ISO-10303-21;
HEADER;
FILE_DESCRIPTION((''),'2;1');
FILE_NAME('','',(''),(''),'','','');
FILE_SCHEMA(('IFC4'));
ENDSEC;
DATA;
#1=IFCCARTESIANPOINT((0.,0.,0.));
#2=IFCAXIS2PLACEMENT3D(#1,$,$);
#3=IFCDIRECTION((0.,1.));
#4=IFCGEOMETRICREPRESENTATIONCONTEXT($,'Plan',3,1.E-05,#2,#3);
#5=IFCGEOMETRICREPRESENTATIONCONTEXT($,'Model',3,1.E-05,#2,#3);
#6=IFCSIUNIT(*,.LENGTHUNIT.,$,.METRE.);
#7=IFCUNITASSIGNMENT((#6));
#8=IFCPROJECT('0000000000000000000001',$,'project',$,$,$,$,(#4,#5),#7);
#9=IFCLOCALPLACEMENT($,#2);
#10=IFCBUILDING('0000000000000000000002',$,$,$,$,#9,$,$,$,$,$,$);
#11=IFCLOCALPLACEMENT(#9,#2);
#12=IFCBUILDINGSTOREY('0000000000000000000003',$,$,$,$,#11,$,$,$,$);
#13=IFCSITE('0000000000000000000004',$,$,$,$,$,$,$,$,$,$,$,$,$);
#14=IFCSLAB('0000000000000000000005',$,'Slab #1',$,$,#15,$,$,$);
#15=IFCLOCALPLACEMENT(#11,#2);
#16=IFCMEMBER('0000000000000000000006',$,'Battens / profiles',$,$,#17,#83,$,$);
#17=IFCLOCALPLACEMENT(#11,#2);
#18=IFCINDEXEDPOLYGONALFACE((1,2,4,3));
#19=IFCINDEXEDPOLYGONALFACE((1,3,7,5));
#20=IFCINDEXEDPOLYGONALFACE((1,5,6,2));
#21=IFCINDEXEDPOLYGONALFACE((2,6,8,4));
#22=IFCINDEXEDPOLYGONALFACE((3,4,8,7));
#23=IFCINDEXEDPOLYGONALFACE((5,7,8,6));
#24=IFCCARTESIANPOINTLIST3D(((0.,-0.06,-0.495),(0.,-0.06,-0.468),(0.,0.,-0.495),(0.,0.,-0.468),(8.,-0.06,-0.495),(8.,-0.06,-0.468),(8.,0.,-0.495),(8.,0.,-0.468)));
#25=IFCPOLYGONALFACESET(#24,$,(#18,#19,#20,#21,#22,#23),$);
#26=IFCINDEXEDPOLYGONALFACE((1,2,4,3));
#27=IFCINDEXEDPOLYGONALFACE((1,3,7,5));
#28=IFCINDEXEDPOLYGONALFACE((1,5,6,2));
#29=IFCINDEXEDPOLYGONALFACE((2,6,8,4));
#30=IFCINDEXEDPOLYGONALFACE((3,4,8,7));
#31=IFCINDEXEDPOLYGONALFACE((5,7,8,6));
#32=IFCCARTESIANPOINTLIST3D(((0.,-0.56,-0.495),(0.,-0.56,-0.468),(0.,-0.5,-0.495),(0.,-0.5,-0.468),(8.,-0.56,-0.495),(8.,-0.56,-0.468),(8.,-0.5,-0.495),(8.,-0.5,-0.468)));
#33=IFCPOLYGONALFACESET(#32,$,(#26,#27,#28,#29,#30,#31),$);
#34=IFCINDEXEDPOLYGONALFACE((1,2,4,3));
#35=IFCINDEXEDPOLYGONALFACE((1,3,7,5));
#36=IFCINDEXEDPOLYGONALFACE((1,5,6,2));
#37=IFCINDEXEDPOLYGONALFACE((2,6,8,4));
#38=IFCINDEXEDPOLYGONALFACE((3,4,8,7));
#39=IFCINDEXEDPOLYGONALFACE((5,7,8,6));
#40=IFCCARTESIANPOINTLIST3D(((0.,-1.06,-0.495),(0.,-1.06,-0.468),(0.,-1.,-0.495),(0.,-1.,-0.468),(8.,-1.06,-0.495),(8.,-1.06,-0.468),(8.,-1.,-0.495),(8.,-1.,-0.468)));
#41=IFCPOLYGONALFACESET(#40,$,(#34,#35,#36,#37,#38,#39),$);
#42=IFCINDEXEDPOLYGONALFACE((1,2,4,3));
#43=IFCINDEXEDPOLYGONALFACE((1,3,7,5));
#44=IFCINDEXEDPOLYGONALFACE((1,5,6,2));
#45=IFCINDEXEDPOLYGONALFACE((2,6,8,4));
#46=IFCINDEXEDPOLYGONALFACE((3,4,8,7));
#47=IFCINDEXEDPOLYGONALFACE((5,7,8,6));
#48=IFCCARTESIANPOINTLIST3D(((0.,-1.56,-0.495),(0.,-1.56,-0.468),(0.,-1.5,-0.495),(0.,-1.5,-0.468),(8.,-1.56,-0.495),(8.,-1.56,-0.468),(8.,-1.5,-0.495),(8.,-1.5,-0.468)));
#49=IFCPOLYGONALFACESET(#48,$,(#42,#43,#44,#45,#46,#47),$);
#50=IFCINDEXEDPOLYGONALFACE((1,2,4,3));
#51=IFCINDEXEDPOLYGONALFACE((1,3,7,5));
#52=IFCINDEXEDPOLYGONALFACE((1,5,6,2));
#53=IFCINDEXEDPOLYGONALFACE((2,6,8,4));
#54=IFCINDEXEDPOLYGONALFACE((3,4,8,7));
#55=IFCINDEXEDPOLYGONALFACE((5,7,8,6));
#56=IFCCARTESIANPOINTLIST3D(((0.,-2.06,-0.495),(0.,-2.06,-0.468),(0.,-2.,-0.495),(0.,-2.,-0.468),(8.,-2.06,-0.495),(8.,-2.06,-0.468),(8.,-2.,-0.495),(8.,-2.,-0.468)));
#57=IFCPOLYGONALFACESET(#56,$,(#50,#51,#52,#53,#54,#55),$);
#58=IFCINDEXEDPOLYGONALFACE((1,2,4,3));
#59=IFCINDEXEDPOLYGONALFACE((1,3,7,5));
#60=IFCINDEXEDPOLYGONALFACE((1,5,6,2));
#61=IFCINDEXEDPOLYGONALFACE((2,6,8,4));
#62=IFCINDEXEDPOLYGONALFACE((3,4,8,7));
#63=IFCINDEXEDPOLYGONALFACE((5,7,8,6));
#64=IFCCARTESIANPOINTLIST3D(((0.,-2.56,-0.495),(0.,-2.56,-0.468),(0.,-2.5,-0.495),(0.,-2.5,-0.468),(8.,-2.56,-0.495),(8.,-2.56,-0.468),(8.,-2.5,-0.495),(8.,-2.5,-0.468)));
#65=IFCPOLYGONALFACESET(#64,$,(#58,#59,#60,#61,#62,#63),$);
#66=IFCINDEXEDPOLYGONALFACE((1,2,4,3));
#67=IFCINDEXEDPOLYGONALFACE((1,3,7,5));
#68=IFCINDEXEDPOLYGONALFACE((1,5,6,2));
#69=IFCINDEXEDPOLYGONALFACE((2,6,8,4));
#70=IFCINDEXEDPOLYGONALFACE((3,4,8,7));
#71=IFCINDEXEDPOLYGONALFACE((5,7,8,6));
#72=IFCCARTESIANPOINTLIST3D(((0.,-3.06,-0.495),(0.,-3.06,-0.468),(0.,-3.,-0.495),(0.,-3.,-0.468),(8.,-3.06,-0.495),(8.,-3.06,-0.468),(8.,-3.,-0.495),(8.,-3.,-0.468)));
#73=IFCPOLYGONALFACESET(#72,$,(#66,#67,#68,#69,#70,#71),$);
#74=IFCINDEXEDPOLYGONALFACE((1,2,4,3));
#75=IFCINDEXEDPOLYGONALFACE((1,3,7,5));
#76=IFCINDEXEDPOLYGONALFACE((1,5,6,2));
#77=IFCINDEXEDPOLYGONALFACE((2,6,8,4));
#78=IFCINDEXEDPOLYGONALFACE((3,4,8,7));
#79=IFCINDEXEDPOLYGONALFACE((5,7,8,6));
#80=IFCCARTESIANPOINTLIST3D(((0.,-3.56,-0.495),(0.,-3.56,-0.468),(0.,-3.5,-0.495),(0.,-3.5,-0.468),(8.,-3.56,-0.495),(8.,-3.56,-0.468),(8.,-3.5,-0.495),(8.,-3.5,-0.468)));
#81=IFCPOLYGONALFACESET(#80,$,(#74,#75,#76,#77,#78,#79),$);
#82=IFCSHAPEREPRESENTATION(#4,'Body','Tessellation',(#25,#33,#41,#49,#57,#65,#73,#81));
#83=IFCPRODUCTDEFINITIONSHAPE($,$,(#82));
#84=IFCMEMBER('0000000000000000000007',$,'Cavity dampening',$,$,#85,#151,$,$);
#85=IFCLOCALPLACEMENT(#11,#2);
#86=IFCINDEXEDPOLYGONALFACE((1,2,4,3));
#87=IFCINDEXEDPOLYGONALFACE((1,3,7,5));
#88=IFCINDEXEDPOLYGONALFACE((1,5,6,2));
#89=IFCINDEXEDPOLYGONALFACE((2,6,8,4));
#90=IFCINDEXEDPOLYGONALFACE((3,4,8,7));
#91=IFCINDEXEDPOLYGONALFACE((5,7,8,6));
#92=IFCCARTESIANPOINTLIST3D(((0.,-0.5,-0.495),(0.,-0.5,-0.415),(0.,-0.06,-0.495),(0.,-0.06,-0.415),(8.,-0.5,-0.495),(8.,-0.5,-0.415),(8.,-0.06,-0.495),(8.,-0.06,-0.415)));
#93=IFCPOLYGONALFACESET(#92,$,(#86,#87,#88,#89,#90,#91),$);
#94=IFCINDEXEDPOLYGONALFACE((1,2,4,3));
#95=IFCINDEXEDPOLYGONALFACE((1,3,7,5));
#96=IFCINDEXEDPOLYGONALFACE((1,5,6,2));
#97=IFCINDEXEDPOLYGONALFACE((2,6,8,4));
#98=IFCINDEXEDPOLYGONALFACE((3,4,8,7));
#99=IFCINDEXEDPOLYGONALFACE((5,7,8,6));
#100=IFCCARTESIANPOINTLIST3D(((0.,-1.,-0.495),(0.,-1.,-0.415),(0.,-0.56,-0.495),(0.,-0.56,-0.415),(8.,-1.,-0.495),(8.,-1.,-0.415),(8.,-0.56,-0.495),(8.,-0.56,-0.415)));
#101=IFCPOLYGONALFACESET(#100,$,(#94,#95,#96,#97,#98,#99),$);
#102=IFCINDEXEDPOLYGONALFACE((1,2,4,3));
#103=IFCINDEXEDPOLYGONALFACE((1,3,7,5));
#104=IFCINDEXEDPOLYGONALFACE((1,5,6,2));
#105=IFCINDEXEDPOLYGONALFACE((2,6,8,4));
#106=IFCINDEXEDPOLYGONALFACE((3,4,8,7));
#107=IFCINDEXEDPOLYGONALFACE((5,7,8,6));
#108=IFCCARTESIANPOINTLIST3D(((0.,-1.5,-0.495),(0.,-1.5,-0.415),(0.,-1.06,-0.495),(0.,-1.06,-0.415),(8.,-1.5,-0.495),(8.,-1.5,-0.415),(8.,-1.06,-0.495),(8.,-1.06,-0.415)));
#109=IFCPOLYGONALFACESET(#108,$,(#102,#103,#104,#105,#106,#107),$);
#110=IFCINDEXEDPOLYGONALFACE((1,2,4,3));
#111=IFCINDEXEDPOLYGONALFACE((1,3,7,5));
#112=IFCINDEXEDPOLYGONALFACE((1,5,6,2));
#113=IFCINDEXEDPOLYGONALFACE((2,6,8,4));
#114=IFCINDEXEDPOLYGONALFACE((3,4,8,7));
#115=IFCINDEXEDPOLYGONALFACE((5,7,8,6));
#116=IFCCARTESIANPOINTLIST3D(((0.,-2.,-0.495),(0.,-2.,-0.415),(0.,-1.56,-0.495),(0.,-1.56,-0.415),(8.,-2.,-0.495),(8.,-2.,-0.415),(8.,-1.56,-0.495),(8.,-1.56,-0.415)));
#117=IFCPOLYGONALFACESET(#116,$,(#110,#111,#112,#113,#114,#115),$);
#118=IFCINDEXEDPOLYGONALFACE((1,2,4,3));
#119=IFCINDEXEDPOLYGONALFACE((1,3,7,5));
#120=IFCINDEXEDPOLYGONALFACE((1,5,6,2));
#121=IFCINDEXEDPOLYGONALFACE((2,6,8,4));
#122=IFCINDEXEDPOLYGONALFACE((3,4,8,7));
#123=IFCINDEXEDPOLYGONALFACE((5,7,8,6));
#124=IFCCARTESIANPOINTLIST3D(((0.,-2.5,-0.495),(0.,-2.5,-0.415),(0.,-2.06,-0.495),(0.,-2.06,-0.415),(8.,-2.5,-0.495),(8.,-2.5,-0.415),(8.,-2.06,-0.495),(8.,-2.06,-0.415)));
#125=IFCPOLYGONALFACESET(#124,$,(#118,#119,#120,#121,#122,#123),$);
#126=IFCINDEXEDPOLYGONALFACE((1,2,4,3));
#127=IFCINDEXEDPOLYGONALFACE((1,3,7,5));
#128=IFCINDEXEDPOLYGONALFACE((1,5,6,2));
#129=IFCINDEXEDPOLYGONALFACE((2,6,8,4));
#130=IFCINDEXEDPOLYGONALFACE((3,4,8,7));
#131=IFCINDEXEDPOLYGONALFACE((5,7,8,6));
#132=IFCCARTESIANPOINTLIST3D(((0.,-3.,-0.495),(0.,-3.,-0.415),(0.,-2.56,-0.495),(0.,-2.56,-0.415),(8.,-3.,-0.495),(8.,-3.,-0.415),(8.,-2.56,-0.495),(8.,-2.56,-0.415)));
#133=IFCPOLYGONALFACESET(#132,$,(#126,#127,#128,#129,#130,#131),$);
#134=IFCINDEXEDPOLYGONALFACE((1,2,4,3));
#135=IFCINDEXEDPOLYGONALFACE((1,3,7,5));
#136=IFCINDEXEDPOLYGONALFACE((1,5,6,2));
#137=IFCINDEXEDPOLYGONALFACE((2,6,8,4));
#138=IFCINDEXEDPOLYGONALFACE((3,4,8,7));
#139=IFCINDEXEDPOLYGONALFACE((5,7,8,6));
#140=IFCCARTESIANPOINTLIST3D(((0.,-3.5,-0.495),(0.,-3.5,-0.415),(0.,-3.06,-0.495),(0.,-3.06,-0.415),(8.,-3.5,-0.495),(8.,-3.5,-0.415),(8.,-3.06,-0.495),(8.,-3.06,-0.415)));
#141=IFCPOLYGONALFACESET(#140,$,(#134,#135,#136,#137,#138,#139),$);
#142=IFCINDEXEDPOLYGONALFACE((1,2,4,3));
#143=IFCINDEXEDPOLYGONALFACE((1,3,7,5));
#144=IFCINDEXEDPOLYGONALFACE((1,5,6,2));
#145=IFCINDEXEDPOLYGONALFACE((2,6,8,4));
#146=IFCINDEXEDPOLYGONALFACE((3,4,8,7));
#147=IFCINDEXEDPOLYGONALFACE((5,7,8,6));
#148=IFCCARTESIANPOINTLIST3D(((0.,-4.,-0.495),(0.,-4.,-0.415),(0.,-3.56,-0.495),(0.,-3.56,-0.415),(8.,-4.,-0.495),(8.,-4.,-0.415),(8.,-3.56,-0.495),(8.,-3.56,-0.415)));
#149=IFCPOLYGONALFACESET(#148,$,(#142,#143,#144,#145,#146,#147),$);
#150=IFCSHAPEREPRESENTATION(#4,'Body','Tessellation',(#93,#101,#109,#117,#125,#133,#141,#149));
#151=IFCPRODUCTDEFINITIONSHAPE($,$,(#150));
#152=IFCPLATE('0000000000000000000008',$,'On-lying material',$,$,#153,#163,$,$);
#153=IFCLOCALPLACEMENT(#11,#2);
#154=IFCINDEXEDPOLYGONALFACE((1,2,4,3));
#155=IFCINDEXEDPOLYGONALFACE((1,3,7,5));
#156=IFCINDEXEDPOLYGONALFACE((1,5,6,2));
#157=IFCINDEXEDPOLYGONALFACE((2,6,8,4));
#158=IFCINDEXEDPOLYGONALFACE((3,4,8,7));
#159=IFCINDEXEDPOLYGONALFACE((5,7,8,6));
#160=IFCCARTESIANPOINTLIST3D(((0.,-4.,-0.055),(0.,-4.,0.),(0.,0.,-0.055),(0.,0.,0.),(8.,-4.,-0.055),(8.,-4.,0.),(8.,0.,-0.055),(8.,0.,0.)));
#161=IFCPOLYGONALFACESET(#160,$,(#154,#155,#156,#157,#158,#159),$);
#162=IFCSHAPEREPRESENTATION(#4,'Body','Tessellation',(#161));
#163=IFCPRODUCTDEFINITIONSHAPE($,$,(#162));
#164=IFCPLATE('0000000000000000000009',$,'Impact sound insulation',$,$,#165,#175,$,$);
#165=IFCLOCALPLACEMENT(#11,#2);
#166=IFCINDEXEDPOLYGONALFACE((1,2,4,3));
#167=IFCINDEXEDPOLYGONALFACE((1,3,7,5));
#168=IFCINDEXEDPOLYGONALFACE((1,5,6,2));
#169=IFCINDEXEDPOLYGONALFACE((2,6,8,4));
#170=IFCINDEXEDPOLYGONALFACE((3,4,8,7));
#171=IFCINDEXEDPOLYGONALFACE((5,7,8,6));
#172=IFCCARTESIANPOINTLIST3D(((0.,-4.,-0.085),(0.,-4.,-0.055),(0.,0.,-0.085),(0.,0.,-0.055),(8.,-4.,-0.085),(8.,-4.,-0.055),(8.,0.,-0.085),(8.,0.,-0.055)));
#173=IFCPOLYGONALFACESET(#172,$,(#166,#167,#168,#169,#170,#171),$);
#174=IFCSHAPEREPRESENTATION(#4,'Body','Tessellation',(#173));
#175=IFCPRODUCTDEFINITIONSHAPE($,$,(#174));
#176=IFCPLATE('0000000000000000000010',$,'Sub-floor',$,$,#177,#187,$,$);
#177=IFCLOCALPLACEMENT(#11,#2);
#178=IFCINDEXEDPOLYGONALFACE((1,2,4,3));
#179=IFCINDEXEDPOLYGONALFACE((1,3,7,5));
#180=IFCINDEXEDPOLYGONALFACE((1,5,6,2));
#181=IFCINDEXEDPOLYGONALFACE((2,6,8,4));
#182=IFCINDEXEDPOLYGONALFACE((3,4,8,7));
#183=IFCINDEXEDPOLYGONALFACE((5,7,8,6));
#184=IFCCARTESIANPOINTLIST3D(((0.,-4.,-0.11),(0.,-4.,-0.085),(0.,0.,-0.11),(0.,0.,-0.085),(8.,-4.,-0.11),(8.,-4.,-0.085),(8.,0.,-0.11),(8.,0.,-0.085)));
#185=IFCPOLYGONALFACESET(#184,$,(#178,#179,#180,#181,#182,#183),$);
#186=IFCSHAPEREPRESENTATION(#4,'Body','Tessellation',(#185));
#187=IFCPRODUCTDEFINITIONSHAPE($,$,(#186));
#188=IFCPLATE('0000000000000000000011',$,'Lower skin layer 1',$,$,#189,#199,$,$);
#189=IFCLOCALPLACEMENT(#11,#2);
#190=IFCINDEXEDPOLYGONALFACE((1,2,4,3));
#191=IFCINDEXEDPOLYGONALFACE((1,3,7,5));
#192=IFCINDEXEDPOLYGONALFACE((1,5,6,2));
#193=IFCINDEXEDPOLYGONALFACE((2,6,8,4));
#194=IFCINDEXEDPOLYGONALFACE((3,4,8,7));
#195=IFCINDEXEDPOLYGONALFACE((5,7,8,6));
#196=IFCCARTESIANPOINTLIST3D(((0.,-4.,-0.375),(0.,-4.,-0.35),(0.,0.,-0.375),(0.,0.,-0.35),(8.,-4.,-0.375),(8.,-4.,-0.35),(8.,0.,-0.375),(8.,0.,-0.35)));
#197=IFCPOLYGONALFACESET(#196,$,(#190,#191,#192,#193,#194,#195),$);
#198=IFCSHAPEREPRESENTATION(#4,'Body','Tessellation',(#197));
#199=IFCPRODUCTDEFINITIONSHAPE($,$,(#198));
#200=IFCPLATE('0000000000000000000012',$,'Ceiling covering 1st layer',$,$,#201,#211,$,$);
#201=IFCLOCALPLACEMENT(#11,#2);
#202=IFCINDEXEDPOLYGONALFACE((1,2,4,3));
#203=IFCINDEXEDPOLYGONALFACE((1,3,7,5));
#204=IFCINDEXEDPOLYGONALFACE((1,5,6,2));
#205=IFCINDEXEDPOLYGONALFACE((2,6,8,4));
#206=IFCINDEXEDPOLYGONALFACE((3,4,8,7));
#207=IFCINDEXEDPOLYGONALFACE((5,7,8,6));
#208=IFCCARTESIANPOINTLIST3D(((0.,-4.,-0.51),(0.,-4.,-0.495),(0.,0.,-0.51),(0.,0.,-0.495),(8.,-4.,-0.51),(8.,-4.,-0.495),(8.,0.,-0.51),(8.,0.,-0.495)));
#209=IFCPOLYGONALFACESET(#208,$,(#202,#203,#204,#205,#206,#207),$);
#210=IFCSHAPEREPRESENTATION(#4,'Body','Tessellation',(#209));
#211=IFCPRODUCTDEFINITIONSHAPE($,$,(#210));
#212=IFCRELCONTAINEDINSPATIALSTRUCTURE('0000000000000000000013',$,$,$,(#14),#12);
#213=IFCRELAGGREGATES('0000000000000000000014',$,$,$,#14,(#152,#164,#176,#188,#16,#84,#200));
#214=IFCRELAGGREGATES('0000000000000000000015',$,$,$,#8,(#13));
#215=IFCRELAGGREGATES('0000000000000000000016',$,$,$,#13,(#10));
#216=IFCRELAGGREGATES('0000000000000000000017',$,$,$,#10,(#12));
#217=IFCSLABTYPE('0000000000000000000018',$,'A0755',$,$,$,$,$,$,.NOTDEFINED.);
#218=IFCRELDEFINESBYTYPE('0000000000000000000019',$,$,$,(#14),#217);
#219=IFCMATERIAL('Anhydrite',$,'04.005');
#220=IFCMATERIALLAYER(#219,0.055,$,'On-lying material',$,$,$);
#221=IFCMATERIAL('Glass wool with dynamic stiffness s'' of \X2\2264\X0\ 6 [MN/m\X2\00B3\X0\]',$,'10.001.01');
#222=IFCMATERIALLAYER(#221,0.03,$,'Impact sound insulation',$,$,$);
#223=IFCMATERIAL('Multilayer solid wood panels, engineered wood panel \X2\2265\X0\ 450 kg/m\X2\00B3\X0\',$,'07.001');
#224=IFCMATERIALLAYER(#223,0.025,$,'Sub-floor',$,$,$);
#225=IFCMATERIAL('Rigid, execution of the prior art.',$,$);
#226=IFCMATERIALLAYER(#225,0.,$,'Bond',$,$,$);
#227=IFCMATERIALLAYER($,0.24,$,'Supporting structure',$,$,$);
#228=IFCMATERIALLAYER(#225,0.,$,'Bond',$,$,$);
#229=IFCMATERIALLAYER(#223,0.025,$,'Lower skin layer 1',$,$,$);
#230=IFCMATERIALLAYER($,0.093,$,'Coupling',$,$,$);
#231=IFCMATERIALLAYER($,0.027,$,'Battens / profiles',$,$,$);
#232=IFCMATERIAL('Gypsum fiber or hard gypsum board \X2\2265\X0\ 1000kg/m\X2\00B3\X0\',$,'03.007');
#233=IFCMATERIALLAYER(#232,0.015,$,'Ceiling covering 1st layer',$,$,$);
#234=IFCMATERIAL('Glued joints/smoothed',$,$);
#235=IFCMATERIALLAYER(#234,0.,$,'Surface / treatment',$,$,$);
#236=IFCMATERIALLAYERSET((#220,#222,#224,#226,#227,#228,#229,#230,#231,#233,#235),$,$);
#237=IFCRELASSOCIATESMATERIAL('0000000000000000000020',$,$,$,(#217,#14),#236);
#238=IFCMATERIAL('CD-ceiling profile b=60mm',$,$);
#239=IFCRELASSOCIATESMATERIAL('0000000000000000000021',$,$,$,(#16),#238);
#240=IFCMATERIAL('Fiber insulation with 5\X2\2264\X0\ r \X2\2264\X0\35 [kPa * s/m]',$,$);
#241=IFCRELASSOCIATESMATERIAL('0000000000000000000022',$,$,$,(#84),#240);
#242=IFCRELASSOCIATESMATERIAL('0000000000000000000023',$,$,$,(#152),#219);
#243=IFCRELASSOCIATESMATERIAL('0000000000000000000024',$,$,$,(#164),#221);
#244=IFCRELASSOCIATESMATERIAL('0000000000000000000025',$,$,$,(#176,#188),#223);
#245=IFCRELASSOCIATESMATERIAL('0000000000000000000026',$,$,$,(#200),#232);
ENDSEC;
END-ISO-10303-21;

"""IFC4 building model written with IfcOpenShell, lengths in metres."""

from ifc_helpers import new_model, si_unit, direction, frame, frame_2d, origin, origin_with_axes, place, context, project, spatial, rectangle, extrude, material, layer, layer_set, type_object, element, aggregate, save


model = new_model("IFC4")

# Units and contexts
plan_context = context("Plan", 3, precision=1e-05, world=origin(), true_north=direction((0.0, 1.0)))
model_context = context("Model", 3, precision=1e-05, world=origin(), true_north=direction((0.0, 1.0)))
ifc_project = project(units=[si_unit("LENGTHUNIT", "METRE")], contexts=[plan_context, model_context])

# Site, building, storey
site = spatial("IfcSite", under=ifc_project)
building_placement = place(None, origin())
building = spatial("IfcBuilding", under=site, at=building_placement)
storey_placement = place(building_placement, origin())
storey = spatial("IfcBuildingStorey", under=building, at=storey_placement)

# Slab, members, plates
ifc_material_1 = material(Name="Anhydrite", Category="04.005")
ifc_layer_1 = layer(ifc_material_1, 0.055, Name="On-lying material")
ifc_material_2 = material(Name="Glass wool with dynamic stiffness s' of ≤ 6 [MN/m³]", Category="10.001.01")
ifc_layer_2 = layer(ifc_material_2, 0.03, Name="Impact sound insulation")
ifc_material_3 = material(Name="Multilayer solid wood panels, engineered wood panel ≥ 450 kg/m³", Category="07.001")
ifc_layer_3 = layer(ifc_material_3, 0.025, Name="Sub-floor")
ifc_material_4 = material(Name="Rigid, execution of the prior art.")
ifc_layer_4 = layer(ifc_material_4, 0.0, Name="Bond")
ifc_layer_5 = layer(None, 0.24, Name="Supporting structure")
ifc_layer_6 = layer(ifc_material_4, 0.0, Name="Bond")
ifc_layer_7 = layer(ifc_material_3, 0.025, Name="Lower skin layer 1")
ifc_layer_8 = layer(None, 0.093, Name="Coupling")
ifc_layer_9 = layer(None, 0.027, Name="Battens / profiles")
ifc_material_5 = material(Name="Gypsum fiber or hard gypsum board ≥ 1000kg/m³", Category="03.007")
ifc_layer_10 = layer(ifc_material_5, 0.015, Name="Ceiling covering 1st layer")
ifc_material_6 = material(Name="Glued joints/smoothed")
ifc_layer_11 = layer(ifc_material_6, 0.0, Name="Surface / treatment")
ifc_layer_set = layer_set([ifc_layer_1, ifc_layer_2, ifc_layer_3, ifc_layer_4, ifc_layer_5, ifc_layer_6, ifc_layer_7, ifc_layer_8, ifc_layer_9, ifc_layer_10, ifc_layer_11])
slab_type = type_object("IfcSlabType", Name="A0755", PredefinedType="NOTDEFINED", material=ifc_layer_set)
slab_placement = place(None, frame((0.0, 0.0, 0.0), z_axis=(0.0, 0.0, -1.0), x_axis=(1.0, 0.0, 0.0)))
slab = element("IfcSlab", 1, at=slab_placement, inside=storey, type_object=slab_type, material=ifc_layer_set, Name="Slab #1")
ifc_material_7 = material(Name="CD-ceiling profile b=60mm")
member_1_placement = place(slab_placement, origin())
member_1 = element("IfcMember", 2, at=member_1_placement, material=ifc_material_7, Name="Battens / profiles", context=plan_context, shape_type="SweptSolid", body=[
    extrude(rectangle(XDim=0.06, YDim=0.027, at=frame_2d((0.03, 0.0135), x_axis=(1.0, 0.0))), frame((0.0, 0.0, 0.468), z_axis=(1.0, 0.0, 0.0), x_axis=(0.0, 1.0, 0.0)), (0.0, 0.0, 1.0), 8.0),
    extrude(rectangle(XDim=0.06, YDim=0.027, at=frame_2d((0.03, 0.0135), x_axis=(1.0, 0.0))), frame((0.0, 0.5, 0.468), z_axis=(1.0, 0.0, 0.0), x_axis=(0.0, 1.0, 0.0)), (0.0, 0.0, 1.0), 8.0),
    extrude(rectangle(XDim=0.06, YDim=0.027, at=frame_2d((0.03, 0.0135), x_axis=(1.0, 0.0))), frame((0.0, 1.0, 0.468), z_axis=(1.0, 0.0, 0.0), x_axis=(0.0, 1.0, 0.0)), (0.0, 0.0, 1.0), 8.0),
    extrude(rectangle(XDim=0.06, YDim=0.027, at=frame_2d((0.03, 0.0135), x_axis=(1.0, 0.0))), frame((0.0, 1.5, 0.468), z_axis=(1.0, 0.0, 0.0), x_axis=(0.0, 1.0, 0.0)), (0.0, 0.0, 1.0), 8.0),
    extrude(rectangle(XDim=0.06, YDim=0.027, at=frame_2d((0.03, 0.0135), x_axis=(1.0, 0.0))), frame((0.0, 2.0, 0.468), z_axis=(1.0, 0.0, 0.0), x_axis=(0.0, 1.0, 0.0)), (0.0, 0.0, 1.0), 8.0),
    extrude(rectangle(XDim=0.06, YDim=0.027, at=frame_2d((0.03, 0.0135), x_axis=(1.0, 0.0))), frame((0.0, 2.5, 0.468), z_axis=(1.0, 0.0, 0.0), x_axis=(0.0, 1.0, 0.0)), (0.0, 0.0, 1.0), 8.0),
    extrude(rectangle(XDim=0.06, YDim=0.027, at=frame_2d((0.03, 0.0135), x_axis=(1.0, 0.0))), frame((0.0, 3.0, 0.468), z_axis=(1.0, 0.0, 0.0), x_axis=(0.0, 1.0, 0.0)), (0.0, 0.0, 1.0), 8.0),
    extrude(rectangle(XDim=0.06, YDim=0.027, at=frame_2d((0.03, 0.0135), x_axis=(1.0, 0.0))), frame((0.0, 3.5, 0.468), z_axis=(1.0, 0.0, 0.0), x_axis=(0.0, 1.0, 0.0)), (0.0, 0.0, 1.0), 8.0),
])
ifc_material_8 = material(Name="Fiber insulation with 5≤ r ≤35 [kPa * s/m]")
member_2_placement = place(slab_placement, origin())
member_2 = element("IfcMember", 3, at=member_2_placement, material=ifc_material_8, Name="Cavity dampening", context=plan_context, shape_type="SweptSolid", body=[
    extrude(rectangle(XDim=0.44, YDim=0.08, at=frame_2d((0.22, 0.04), x_axis=(1.0, 0.0))), frame((0.0, 0.06, 0.415), z_axis=(1.0, 0.0, 0.0), x_axis=(0.0, 1.0, 0.0)), (0.0, 0.0, 1.0), 8.0),
    extrude(rectangle(XDim=0.44, YDim=0.08, at=frame_2d((0.22, 0.04), x_axis=(1.0, 0.0))), frame((0.0, 0.56, 0.415), z_axis=(1.0, 0.0, 0.0), x_axis=(0.0, 1.0, 0.0)), (0.0, 0.0, 1.0), 8.0),
    extrude(rectangle(XDim=0.44, YDim=0.08, at=frame_2d((0.22, 0.04), x_axis=(1.0, 0.0))), frame((0.0, 1.06, 0.415), z_axis=(1.0, 0.0, 0.0), x_axis=(0.0, 1.0, 0.0)), (0.0, 0.0, 1.0), 8.0),
    extrude(rectangle(XDim=0.44, YDim=0.08, at=frame_2d((0.22, 0.04), x_axis=(1.0, 0.0))), frame((0.0, 1.56, 0.415), z_axis=(1.0, 0.0, 0.0), x_axis=(0.0, 1.0, 0.0)), (0.0, 0.0, 1.0), 8.0),
    extrude(rectangle(XDim=0.44, YDim=0.08, at=frame_2d((0.22, 0.04), x_axis=(1.0, 0.0))), frame((0.0, 2.06, 0.415), z_axis=(1.0, 0.0, 0.0), x_axis=(0.0, 1.0, 0.0)), (0.0, 0.0, 1.0), 8.0),
    extrude(rectangle(XDim=0.44, YDim=0.08, at=frame_2d((0.22, 0.04), x_axis=(1.0, 0.0))), frame((0.0, 2.56, 0.415), z_axis=(1.0, 0.0, 0.0), x_axis=(0.0, 1.0, 0.0)), (0.0, 0.0, 1.0), 8.0),
    extrude(rectangle(XDim=0.44, YDim=0.08, at=frame_2d((0.22, 0.04), x_axis=(1.0, 0.0))), frame((0.0, 3.06, 0.415), z_axis=(1.0, 0.0, 0.0), x_axis=(0.0, 1.0, 0.0)), (0.0, 0.0, 1.0), 8.0),
    extrude(rectangle(XDim=0.44, YDim=0.08, at=frame_2d((0.22, 0.04), x_axis=(1.0, 0.0))), frame((0.0, 3.56, 0.415), z_axis=(1.0, 0.0, 0.0), x_axis=(0.0, 1.0, 0.0)), (0.0, 0.0, 1.0), 8.0),
])
plate_1_placement = place(slab_placement, origin())
plate_1 = element("IfcPlate", 4, at=plate_1_placement, material=ifc_material_1, Name="On-lying material", context=plan_context, shape_type="SweptSolid", body=[
    extrude(rectangle(XDim=8.0, YDim=4.0, at=frame_2d((4.0, 2.0), x_axis=(1.0, 0.0))), origin_with_axes(), (0.0, 0.0, 1.0), 0.055),
])
plate_2_placement = place(slab_placement, origin())
plate_2 = element("IfcPlate", 5, at=plate_2_placement, material=ifc_material_2, Name="Impact sound insulation", context=plan_context, shape_type="SweptSolid", body=[
    extrude(rectangle(XDim=8.0, YDim=4.0, at=frame_2d((4.0, 2.0), x_axis=(1.0, 0.0))), frame((0.0, 0.0, 0.055), z_axis=(0.0, 0.0, 1.0), x_axis=(1.0, 0.0, 0.0)), (0.0, 0.0, 1.0), 0.03),
])
plate_3_placement = place(slab_placement, origin())
plate_3 = element("IfcPlate", 6, at=plate_3_placement, material=ifc_material_3, Name="Sub-floor", context=plan_context, shape_type="SweptSolid", body=[
    extrude(rectangle(XDim=8.0, YDim=4.0, at=frame_2d((4.0, 2.0), x_axis=(1.0, 0.0))), frame((0.0, 0.0, 0.085), z_axis=(0.0, 0.0, 1.0), x_axis=(1.0, 0.0, 0.0)), (0.0, 0.0, 1.0), 0.025),
])
plate_4_placement = place(slab_placement, origin())
plate_4 = element("IfcPlate", 7, at=plate_4_placement, material=ifc_material_3, Name="Lower skin layer 1", context=plan_context, shape_type="SweptSolid", body=[
    extrude(rectangle(XDim=8.0, YDim=4.0, at=frame_2d((4.0, 2.0), x_axis=(1.0, 0.0))), frame((0.0, 0.0, 0.35), z_axis=(0.0, 0.0, 1.0), x_axis=(1.0, 0.0, 0.0)), (0.0, 0.0, 1.0), 0.025),
])
plate_5_placement = place(slab_placement, origin())
plate_5 = element("IfcPlate", 8, at=plate_5_placement, material=ifc_material_5, Name="Ceiling covering 1st layer", context=plan_context, shape_type="SweptSolid", body=[
    extrude(rectangle(XDim=8.0, YDim=4.0, at=frame_2d((4.0, 2.0), x_axis=(1.0, 0.0))), frame((0.0, 0.0, 0.495), z_axis=(0.0, 0.0, 1.0), x_axis=(1.0, 0.0, 0.0)), (0.0, 0.0, 1.0), 0.015),
])
aggregate(slab, [plate_1, plate_2, plate_3, plate_4, member_1, member_2, plate_5])

save(model, "model.ifc")
